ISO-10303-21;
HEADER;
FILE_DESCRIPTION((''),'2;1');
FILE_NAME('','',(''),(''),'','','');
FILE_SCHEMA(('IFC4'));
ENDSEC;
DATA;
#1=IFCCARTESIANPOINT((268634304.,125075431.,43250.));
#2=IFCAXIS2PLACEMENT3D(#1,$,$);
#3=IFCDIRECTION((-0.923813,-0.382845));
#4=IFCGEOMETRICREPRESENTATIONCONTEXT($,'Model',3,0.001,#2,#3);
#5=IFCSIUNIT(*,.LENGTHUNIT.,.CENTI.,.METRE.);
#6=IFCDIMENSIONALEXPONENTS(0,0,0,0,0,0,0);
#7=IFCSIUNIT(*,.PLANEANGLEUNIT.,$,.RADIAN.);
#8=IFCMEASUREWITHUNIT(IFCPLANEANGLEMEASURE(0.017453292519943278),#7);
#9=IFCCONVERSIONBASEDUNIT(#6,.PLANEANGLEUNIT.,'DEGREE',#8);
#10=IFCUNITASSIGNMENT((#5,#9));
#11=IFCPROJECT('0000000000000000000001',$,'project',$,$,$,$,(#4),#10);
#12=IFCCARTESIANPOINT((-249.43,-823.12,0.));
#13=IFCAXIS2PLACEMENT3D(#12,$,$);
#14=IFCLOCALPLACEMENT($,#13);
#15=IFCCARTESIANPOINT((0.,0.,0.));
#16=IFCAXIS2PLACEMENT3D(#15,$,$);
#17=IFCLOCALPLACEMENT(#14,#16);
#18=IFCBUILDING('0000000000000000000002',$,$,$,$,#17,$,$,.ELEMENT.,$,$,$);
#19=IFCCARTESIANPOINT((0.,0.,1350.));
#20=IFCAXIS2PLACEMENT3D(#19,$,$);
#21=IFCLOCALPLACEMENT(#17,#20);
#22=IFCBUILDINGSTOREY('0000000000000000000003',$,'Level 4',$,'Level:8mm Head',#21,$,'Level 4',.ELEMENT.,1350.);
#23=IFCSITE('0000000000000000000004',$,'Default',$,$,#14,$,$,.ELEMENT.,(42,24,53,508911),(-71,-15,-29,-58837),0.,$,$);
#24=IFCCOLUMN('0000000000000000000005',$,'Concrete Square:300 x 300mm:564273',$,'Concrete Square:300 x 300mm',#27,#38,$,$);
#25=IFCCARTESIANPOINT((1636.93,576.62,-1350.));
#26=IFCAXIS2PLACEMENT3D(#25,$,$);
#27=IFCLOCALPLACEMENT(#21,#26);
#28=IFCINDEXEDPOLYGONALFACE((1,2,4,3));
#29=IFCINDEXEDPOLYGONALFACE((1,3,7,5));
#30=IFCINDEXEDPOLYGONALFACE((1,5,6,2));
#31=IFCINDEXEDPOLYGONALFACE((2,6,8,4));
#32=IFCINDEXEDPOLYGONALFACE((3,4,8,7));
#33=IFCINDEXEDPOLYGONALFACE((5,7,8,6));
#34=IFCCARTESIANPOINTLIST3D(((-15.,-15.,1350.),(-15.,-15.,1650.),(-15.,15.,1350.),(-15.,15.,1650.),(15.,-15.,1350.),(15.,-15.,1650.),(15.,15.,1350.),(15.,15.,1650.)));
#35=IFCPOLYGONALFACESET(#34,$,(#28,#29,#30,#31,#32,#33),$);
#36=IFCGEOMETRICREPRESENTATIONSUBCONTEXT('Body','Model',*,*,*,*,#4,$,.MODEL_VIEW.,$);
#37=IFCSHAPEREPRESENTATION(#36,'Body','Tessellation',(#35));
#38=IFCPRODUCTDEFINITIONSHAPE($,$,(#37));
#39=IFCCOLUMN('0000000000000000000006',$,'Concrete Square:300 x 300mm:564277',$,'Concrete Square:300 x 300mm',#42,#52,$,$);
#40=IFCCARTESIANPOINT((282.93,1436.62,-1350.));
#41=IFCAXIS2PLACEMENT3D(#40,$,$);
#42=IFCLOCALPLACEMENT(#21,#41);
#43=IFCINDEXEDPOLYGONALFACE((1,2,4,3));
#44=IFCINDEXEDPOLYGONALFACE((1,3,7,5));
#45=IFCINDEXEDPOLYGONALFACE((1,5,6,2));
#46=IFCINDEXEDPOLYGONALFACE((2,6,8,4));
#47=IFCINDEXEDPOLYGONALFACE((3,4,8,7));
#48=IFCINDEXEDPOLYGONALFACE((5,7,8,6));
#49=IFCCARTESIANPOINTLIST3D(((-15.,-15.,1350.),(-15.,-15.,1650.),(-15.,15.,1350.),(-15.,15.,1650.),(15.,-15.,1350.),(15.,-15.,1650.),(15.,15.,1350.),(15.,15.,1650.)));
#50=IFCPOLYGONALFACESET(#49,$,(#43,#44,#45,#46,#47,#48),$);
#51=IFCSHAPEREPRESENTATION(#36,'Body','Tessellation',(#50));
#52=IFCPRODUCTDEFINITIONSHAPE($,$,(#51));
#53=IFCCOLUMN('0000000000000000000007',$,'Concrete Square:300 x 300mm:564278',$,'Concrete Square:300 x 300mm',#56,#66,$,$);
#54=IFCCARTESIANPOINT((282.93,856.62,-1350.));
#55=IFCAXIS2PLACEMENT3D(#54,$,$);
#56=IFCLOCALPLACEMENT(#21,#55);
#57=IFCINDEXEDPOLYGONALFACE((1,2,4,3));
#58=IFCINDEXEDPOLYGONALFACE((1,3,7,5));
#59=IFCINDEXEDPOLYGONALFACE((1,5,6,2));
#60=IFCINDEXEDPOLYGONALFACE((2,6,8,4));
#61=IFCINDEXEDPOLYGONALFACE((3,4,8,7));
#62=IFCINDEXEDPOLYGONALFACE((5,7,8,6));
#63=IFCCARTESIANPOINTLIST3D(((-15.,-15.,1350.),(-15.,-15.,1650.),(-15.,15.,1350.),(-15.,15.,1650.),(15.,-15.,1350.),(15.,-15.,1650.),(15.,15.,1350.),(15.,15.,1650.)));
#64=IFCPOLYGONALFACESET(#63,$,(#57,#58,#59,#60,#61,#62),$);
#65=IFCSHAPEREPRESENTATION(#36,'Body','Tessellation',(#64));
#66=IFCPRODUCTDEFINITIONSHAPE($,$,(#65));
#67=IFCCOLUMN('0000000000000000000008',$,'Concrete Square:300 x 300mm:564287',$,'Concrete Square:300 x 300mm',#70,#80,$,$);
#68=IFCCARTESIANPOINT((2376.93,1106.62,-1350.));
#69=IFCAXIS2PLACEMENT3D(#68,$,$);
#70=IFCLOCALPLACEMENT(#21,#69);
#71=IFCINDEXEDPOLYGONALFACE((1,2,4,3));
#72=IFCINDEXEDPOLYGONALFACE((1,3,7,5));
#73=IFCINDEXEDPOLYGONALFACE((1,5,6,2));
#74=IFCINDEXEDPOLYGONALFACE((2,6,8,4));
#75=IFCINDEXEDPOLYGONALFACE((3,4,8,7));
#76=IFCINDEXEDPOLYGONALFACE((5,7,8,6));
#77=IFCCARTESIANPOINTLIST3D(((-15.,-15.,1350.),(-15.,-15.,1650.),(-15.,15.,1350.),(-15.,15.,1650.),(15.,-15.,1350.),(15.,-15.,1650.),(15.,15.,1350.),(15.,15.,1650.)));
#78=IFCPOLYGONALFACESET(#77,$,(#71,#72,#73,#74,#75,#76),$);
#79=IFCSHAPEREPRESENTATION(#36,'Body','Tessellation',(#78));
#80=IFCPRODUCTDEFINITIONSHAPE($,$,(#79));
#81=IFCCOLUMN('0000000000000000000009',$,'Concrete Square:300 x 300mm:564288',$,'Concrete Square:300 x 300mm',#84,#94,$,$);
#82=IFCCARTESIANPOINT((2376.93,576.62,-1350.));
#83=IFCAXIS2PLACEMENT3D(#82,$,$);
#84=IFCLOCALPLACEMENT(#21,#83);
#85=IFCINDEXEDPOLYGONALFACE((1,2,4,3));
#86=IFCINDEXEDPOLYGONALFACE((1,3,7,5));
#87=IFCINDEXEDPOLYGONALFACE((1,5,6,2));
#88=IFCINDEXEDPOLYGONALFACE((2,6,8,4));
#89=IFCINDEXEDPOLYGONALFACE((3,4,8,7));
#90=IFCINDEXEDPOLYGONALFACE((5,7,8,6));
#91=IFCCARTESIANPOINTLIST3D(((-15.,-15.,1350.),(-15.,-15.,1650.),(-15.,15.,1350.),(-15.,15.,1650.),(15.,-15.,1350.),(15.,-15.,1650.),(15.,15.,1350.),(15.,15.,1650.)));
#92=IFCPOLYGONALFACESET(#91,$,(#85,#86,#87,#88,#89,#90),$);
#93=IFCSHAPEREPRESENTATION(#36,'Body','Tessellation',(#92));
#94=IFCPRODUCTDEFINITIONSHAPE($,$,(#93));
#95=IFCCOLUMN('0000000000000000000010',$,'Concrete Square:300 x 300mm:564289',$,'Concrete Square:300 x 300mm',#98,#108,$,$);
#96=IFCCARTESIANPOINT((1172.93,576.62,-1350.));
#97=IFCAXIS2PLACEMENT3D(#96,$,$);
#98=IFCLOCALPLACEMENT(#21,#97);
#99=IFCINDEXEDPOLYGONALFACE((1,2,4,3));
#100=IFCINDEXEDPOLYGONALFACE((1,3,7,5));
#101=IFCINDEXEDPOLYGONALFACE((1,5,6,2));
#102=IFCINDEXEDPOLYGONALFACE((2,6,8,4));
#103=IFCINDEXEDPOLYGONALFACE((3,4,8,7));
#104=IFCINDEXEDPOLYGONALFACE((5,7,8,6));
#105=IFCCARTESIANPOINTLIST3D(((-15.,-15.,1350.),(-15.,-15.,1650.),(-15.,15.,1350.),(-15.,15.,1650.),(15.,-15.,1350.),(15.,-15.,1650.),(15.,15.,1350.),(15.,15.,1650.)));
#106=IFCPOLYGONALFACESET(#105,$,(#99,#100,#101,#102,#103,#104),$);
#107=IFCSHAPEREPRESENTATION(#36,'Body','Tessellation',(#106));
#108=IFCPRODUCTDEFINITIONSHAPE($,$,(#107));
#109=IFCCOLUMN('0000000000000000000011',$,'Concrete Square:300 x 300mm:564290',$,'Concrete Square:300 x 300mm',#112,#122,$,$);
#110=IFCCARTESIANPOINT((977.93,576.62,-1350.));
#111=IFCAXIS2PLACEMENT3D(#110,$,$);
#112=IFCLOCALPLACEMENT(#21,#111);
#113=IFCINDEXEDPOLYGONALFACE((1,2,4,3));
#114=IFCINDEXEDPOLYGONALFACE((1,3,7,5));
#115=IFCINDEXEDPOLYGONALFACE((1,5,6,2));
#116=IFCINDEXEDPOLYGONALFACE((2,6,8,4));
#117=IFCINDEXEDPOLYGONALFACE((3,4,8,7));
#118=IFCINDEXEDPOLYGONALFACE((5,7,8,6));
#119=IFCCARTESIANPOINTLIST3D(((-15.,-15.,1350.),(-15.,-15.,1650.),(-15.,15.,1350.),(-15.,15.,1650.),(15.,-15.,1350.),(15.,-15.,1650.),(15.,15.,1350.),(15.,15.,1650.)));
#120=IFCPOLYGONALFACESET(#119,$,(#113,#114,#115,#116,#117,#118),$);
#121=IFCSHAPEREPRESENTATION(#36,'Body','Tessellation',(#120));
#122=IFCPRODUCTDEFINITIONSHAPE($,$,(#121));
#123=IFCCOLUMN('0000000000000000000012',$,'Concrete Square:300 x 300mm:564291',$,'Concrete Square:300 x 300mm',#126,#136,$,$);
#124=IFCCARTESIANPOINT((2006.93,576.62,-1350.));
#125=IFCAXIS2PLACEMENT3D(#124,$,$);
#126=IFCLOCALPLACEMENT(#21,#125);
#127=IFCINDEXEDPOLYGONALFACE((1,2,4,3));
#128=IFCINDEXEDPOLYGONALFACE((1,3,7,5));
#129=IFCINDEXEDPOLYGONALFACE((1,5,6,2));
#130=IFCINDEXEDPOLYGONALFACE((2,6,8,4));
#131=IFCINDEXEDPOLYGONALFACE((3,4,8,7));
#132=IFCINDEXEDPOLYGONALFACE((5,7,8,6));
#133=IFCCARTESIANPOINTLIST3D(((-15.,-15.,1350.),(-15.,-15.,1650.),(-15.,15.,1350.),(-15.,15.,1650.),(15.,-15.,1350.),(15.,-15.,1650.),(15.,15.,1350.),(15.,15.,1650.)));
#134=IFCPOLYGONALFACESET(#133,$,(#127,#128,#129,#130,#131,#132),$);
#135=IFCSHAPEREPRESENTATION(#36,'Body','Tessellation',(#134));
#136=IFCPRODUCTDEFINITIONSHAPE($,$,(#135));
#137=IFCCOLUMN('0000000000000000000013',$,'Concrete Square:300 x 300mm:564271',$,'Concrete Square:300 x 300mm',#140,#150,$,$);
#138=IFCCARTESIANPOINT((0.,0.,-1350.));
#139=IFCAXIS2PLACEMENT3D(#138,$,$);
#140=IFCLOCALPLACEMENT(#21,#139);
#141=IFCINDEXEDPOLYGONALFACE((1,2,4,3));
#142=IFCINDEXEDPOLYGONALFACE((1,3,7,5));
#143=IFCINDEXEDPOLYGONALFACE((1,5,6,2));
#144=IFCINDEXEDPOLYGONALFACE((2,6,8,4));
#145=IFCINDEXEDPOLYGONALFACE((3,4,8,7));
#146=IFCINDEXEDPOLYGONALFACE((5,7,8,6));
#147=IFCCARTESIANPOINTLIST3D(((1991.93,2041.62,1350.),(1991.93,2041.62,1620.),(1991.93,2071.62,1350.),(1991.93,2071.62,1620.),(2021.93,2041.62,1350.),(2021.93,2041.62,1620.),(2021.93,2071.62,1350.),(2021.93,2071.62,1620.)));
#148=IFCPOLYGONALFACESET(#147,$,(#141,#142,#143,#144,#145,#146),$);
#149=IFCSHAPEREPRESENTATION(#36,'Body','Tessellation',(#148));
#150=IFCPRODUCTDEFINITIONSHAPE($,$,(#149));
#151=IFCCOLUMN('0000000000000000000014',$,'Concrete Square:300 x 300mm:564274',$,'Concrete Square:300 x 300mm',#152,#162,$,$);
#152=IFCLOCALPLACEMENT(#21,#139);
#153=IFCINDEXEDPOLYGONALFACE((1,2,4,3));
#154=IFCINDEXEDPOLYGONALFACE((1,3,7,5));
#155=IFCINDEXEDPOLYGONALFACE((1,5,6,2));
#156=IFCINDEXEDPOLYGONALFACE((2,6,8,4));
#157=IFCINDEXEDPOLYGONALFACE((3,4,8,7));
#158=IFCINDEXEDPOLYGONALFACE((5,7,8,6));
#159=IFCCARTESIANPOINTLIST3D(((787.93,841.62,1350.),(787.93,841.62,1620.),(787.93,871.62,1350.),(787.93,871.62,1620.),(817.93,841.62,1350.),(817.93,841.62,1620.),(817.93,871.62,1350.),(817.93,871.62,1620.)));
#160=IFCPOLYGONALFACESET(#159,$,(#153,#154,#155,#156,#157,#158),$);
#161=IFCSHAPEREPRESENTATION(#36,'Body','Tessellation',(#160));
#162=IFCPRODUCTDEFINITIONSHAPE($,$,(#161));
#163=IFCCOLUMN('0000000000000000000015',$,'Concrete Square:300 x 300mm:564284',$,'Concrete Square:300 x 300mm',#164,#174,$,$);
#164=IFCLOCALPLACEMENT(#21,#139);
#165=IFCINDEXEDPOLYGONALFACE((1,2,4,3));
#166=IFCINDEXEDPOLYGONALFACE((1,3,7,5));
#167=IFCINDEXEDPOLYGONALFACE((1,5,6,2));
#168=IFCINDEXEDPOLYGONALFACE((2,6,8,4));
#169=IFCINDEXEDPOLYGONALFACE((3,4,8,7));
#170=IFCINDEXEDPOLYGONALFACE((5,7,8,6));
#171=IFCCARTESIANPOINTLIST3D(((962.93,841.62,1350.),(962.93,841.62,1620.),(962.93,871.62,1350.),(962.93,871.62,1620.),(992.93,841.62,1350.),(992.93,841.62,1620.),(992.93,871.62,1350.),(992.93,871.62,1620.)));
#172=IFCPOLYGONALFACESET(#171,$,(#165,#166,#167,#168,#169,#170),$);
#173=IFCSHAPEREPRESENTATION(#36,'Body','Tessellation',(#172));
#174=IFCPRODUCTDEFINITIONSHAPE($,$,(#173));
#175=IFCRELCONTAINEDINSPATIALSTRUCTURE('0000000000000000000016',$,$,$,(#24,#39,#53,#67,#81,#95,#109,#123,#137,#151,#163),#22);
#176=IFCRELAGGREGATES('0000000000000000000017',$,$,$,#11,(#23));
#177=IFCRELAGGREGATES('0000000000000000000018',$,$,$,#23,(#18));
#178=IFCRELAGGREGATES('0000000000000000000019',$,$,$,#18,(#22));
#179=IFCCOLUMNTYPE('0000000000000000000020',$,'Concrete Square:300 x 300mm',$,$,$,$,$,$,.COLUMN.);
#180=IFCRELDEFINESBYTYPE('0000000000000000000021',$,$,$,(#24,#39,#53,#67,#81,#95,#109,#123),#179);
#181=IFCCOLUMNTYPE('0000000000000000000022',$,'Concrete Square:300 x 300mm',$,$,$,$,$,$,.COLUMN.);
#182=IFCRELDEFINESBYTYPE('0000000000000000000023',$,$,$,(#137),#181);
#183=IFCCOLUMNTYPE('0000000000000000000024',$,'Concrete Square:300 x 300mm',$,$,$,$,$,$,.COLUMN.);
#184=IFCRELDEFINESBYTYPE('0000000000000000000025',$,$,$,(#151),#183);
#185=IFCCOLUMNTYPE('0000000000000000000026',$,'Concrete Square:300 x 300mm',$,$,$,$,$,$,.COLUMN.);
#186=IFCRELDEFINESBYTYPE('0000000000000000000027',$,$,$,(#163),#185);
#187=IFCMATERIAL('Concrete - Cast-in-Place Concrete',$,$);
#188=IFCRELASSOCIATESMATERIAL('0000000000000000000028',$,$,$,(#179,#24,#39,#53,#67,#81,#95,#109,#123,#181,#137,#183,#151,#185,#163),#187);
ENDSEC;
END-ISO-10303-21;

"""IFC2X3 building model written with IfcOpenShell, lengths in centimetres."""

from ifc_helpers import new_model, entity, si_unit, converted_unit, direction, frame, frame_2d, origin, origin_2d_with_axis, place, context, subcontext, project, spatial, rectangle, extrude, source, transform, mapped, material, type_object, type_shapes, element, save


model = new_model("IFC2X3")

# Units and contexts
model_context = context("Model", 3, precision=0.001, world=frame((268634304.0, 125075431.0, 43250.0)), true_north=direction((-0.923813, -0.382845)))
body_context = subcontext(model_context, "Body", "Model", "MODEL_VIEW")
ifc_project = project(units=[si_unit("LENGTHUNIT", "METRE", prefix="CENTI"), converted_unit("PLANEANGLEUNIT", "DEGREE", entity("IfcPlaneAngleMeasure", 0.017453292519943278), si_unit("PLANEANGLEUNIT", "RADIAN"), dimensions=[0, 0, 0, 0, 0, 0, 0])], contexts=[model_context])

# Site, building, storey
site_placement = place(None, frame((-249.43, -823.12, 0.0)))
site = spatial("IfcSite", under=ifc_project, at=site_placement, Name="Default", CompositionType="ELEMENT", RefLatitude=(42, 24, 53, 508911), RefLongitude=(-71, -15, -29, -58837), RefElevation=0.0)
building_placement = place(site_placement, origin())
building = spatial("IfcBuilding", under=site, at=building_placement, CompositionType="ELEMENT")
storey_placement = place(building_placement, frame((0.0, 0.0, 1350.0)))
storey = spatial("IfcBuildingStorey", under=building, at=storey_placement, Name="Level 4", ObjectType="Level:8mm Head", LongName="Level 4", CompositionType="ELEMENT", Elevation=1350.0)

# Columns
ifc_material_1 = material(Name="Concrete - Cast-in-Place Concrete")
column_type_1 = type_object("IfcColumnType", Name="Concrete Square:300 x 300mm", PredefinedType="COLUMN", material=ifc_material_1)
shared_shape_1 = source(origin(), body_context, "Body", "SweptSolid", [
    extrude(rectangle(XDim=30.0, YDim=30.0, at=origin_2d_with_axis()), frame((0.0, 0.0, 1350.0), z_axis=(0.0, 0.0, 1.0), x_axis=(-1.0, 0.0, 0.0)), (0.0, 0.0, 1.0), 300.0),
])
type_shapes(column_type_1, [shared_shape_1])
for number, where, name in (
    (1, (1636.93, 576.62, -1350.0), "Concrete Square:300 x 300mm:564273"),
    (2, (282.93, 1436.62, -1350.0), "Concrete Square:300 x 300mm:564277"),
    (3, (282.93, 856.62, -1350.0), "Concrete Square:300 x 300mm:564278"),
    (4, (2376.93, 1106.62, -1350.0), "Concrete Square:300 x 300mm:564287"),
    (5, (2376.93, 576.62, -1350.0), "Concrete Square:300 x 300mm:564288"),
    (6, (1172.93, 576.62, -1350.0), "Concrete Square:300 x 300mm:564289"),
    (7, (977.93, 576.62, -1350.0), "Concrete Square:300 x 300mm:564290"),
    (8, (2006.93, 576.62, -1350.0), "Concrete Square:300 x 300mm:564291"),
):
    element("IfcColumn", number, at=place(storey_placement, frame(where)), inside=storey, type_object=column_type_1, material=ifc_material_1, Name=name, ObjectType="Concrete Square:300 x 300mm", context=body_context, shape_type="MappedRepresentation", body=[
        mapped(shared_shape_1, transform((0.0, 0.0, 0.0), scale=1.0)),
    ])
column_type_2 = type_object("IfcColumnType", Name="Concrete Square:300 x 300mm", PredefinedType="COLUMN", material=ifc_material_1)
shared_shape_2 = source(origin(), body_context, "Body", "SweptSolid", [
    extrude(rectangle(XDim=30.0, YDim=30.0, at=origin_2d_with_axis()), frame((2006.93, 2056.62, 1350.0), z_axis=(0.0, 0.0, 1.0), x_axis=(-1.0, 0.0, 0.0)), (0.0, 0.0, 1.0), 270.0),
])
type_shapes(column_type_2, [shared_shape_2])
column_1_placement = place(storey_placement, frame((0.0, 0.0, -1350.0)))
element("IfcColumn", 9, at=column_1_placement, inside=storey, type_object=column_type_2, material=ifc_material_1, Name="Concrete Square:300 x 300mm:564271", ObjectType="Concrete Square:300 x 300mm", context=body_context, shape_type="MappedRepresentation", body=[
    mapped(shared_shape_2, transform((0.0, 0.0, 0.0), scale=1.0)),
])
column_type_3 = type_object("IfcColumnType", Name="Concrete Square:300 x 300mm", PredefinedType="COLUMN", material=ifc_material_1)
shared_shape_3 = source(origin(), body_context, "Body", "SweptSolid", [
    extrude(rectangle(XDim=30.0, YDim=30.0, at=frame_2d((0.0, 0.0), x_axis=(1.0, 0.0))), frame((802.93, 856.62, 1350.0), z_axis=(0.0, 0.0, 1.0), x_axis=(-1.0, 0.0, 0.0)), (0.0, 0.0, 1.0), 270.0),
])
type_shapes(column_type_3, [shared_shape_3])
column_2_placement = place(storey_placement, frame((0.0, 0.0, -1350.0)))
element("IfcColumn", 10, at=column_2_placement, inside=storey, type_object=column_type_3, material=ifc_material_1, Name="Concrete Square:300 x 300mm:564274", ObjectType="Concrete Square:300 x 300mm", context=body_context, shape_type="MappedRepresentation", body=[
    mapped(shared_shape_3, transform((0.0, 0.0, 0.0), scale=1.0)),
])
column_type_4 = type_object("IfcColumnType", Name="Concrete Square:300 x 300mm", PredefinedType="COLUMN", material=ifc_material_1)
shared_shape_4 = source(origin(), body_context, "Body", "SweptSolid", [
    extrude(rectangle(XDim=30.0, YDim=30.0, at=frame_2d((0.0, 0.0), x_axis=(1.0, 0.0))), frame((977.93, 856.62, 1350.0), z_axis=(0.0, 0.0, 1.0), x_axis=(-1.0, 0.0, 0.0)), (0.0, 0.0, 1.0), 270.0),
])
type_shapes(column_type_4, [shared_shape_4])
column_3_placement = place(storey_placement, frame((0.0, 0.0, -1350.0)))
element("IfcColumn", 11, at=column_3_placement, inside=storey, type_object=column_type_4, material=ifc_material_1, Name="Concrete Square:300 x 300mm:564284", ObjectType="Concrete Square:300 x 300mm", context=body_context, shape_type="MappedRepresentation", body=[
    mapped(shared_shape_4, transform((0.0, 0.0, 0.0), scale=1.0)),
])

save(model, "model.ifc")
